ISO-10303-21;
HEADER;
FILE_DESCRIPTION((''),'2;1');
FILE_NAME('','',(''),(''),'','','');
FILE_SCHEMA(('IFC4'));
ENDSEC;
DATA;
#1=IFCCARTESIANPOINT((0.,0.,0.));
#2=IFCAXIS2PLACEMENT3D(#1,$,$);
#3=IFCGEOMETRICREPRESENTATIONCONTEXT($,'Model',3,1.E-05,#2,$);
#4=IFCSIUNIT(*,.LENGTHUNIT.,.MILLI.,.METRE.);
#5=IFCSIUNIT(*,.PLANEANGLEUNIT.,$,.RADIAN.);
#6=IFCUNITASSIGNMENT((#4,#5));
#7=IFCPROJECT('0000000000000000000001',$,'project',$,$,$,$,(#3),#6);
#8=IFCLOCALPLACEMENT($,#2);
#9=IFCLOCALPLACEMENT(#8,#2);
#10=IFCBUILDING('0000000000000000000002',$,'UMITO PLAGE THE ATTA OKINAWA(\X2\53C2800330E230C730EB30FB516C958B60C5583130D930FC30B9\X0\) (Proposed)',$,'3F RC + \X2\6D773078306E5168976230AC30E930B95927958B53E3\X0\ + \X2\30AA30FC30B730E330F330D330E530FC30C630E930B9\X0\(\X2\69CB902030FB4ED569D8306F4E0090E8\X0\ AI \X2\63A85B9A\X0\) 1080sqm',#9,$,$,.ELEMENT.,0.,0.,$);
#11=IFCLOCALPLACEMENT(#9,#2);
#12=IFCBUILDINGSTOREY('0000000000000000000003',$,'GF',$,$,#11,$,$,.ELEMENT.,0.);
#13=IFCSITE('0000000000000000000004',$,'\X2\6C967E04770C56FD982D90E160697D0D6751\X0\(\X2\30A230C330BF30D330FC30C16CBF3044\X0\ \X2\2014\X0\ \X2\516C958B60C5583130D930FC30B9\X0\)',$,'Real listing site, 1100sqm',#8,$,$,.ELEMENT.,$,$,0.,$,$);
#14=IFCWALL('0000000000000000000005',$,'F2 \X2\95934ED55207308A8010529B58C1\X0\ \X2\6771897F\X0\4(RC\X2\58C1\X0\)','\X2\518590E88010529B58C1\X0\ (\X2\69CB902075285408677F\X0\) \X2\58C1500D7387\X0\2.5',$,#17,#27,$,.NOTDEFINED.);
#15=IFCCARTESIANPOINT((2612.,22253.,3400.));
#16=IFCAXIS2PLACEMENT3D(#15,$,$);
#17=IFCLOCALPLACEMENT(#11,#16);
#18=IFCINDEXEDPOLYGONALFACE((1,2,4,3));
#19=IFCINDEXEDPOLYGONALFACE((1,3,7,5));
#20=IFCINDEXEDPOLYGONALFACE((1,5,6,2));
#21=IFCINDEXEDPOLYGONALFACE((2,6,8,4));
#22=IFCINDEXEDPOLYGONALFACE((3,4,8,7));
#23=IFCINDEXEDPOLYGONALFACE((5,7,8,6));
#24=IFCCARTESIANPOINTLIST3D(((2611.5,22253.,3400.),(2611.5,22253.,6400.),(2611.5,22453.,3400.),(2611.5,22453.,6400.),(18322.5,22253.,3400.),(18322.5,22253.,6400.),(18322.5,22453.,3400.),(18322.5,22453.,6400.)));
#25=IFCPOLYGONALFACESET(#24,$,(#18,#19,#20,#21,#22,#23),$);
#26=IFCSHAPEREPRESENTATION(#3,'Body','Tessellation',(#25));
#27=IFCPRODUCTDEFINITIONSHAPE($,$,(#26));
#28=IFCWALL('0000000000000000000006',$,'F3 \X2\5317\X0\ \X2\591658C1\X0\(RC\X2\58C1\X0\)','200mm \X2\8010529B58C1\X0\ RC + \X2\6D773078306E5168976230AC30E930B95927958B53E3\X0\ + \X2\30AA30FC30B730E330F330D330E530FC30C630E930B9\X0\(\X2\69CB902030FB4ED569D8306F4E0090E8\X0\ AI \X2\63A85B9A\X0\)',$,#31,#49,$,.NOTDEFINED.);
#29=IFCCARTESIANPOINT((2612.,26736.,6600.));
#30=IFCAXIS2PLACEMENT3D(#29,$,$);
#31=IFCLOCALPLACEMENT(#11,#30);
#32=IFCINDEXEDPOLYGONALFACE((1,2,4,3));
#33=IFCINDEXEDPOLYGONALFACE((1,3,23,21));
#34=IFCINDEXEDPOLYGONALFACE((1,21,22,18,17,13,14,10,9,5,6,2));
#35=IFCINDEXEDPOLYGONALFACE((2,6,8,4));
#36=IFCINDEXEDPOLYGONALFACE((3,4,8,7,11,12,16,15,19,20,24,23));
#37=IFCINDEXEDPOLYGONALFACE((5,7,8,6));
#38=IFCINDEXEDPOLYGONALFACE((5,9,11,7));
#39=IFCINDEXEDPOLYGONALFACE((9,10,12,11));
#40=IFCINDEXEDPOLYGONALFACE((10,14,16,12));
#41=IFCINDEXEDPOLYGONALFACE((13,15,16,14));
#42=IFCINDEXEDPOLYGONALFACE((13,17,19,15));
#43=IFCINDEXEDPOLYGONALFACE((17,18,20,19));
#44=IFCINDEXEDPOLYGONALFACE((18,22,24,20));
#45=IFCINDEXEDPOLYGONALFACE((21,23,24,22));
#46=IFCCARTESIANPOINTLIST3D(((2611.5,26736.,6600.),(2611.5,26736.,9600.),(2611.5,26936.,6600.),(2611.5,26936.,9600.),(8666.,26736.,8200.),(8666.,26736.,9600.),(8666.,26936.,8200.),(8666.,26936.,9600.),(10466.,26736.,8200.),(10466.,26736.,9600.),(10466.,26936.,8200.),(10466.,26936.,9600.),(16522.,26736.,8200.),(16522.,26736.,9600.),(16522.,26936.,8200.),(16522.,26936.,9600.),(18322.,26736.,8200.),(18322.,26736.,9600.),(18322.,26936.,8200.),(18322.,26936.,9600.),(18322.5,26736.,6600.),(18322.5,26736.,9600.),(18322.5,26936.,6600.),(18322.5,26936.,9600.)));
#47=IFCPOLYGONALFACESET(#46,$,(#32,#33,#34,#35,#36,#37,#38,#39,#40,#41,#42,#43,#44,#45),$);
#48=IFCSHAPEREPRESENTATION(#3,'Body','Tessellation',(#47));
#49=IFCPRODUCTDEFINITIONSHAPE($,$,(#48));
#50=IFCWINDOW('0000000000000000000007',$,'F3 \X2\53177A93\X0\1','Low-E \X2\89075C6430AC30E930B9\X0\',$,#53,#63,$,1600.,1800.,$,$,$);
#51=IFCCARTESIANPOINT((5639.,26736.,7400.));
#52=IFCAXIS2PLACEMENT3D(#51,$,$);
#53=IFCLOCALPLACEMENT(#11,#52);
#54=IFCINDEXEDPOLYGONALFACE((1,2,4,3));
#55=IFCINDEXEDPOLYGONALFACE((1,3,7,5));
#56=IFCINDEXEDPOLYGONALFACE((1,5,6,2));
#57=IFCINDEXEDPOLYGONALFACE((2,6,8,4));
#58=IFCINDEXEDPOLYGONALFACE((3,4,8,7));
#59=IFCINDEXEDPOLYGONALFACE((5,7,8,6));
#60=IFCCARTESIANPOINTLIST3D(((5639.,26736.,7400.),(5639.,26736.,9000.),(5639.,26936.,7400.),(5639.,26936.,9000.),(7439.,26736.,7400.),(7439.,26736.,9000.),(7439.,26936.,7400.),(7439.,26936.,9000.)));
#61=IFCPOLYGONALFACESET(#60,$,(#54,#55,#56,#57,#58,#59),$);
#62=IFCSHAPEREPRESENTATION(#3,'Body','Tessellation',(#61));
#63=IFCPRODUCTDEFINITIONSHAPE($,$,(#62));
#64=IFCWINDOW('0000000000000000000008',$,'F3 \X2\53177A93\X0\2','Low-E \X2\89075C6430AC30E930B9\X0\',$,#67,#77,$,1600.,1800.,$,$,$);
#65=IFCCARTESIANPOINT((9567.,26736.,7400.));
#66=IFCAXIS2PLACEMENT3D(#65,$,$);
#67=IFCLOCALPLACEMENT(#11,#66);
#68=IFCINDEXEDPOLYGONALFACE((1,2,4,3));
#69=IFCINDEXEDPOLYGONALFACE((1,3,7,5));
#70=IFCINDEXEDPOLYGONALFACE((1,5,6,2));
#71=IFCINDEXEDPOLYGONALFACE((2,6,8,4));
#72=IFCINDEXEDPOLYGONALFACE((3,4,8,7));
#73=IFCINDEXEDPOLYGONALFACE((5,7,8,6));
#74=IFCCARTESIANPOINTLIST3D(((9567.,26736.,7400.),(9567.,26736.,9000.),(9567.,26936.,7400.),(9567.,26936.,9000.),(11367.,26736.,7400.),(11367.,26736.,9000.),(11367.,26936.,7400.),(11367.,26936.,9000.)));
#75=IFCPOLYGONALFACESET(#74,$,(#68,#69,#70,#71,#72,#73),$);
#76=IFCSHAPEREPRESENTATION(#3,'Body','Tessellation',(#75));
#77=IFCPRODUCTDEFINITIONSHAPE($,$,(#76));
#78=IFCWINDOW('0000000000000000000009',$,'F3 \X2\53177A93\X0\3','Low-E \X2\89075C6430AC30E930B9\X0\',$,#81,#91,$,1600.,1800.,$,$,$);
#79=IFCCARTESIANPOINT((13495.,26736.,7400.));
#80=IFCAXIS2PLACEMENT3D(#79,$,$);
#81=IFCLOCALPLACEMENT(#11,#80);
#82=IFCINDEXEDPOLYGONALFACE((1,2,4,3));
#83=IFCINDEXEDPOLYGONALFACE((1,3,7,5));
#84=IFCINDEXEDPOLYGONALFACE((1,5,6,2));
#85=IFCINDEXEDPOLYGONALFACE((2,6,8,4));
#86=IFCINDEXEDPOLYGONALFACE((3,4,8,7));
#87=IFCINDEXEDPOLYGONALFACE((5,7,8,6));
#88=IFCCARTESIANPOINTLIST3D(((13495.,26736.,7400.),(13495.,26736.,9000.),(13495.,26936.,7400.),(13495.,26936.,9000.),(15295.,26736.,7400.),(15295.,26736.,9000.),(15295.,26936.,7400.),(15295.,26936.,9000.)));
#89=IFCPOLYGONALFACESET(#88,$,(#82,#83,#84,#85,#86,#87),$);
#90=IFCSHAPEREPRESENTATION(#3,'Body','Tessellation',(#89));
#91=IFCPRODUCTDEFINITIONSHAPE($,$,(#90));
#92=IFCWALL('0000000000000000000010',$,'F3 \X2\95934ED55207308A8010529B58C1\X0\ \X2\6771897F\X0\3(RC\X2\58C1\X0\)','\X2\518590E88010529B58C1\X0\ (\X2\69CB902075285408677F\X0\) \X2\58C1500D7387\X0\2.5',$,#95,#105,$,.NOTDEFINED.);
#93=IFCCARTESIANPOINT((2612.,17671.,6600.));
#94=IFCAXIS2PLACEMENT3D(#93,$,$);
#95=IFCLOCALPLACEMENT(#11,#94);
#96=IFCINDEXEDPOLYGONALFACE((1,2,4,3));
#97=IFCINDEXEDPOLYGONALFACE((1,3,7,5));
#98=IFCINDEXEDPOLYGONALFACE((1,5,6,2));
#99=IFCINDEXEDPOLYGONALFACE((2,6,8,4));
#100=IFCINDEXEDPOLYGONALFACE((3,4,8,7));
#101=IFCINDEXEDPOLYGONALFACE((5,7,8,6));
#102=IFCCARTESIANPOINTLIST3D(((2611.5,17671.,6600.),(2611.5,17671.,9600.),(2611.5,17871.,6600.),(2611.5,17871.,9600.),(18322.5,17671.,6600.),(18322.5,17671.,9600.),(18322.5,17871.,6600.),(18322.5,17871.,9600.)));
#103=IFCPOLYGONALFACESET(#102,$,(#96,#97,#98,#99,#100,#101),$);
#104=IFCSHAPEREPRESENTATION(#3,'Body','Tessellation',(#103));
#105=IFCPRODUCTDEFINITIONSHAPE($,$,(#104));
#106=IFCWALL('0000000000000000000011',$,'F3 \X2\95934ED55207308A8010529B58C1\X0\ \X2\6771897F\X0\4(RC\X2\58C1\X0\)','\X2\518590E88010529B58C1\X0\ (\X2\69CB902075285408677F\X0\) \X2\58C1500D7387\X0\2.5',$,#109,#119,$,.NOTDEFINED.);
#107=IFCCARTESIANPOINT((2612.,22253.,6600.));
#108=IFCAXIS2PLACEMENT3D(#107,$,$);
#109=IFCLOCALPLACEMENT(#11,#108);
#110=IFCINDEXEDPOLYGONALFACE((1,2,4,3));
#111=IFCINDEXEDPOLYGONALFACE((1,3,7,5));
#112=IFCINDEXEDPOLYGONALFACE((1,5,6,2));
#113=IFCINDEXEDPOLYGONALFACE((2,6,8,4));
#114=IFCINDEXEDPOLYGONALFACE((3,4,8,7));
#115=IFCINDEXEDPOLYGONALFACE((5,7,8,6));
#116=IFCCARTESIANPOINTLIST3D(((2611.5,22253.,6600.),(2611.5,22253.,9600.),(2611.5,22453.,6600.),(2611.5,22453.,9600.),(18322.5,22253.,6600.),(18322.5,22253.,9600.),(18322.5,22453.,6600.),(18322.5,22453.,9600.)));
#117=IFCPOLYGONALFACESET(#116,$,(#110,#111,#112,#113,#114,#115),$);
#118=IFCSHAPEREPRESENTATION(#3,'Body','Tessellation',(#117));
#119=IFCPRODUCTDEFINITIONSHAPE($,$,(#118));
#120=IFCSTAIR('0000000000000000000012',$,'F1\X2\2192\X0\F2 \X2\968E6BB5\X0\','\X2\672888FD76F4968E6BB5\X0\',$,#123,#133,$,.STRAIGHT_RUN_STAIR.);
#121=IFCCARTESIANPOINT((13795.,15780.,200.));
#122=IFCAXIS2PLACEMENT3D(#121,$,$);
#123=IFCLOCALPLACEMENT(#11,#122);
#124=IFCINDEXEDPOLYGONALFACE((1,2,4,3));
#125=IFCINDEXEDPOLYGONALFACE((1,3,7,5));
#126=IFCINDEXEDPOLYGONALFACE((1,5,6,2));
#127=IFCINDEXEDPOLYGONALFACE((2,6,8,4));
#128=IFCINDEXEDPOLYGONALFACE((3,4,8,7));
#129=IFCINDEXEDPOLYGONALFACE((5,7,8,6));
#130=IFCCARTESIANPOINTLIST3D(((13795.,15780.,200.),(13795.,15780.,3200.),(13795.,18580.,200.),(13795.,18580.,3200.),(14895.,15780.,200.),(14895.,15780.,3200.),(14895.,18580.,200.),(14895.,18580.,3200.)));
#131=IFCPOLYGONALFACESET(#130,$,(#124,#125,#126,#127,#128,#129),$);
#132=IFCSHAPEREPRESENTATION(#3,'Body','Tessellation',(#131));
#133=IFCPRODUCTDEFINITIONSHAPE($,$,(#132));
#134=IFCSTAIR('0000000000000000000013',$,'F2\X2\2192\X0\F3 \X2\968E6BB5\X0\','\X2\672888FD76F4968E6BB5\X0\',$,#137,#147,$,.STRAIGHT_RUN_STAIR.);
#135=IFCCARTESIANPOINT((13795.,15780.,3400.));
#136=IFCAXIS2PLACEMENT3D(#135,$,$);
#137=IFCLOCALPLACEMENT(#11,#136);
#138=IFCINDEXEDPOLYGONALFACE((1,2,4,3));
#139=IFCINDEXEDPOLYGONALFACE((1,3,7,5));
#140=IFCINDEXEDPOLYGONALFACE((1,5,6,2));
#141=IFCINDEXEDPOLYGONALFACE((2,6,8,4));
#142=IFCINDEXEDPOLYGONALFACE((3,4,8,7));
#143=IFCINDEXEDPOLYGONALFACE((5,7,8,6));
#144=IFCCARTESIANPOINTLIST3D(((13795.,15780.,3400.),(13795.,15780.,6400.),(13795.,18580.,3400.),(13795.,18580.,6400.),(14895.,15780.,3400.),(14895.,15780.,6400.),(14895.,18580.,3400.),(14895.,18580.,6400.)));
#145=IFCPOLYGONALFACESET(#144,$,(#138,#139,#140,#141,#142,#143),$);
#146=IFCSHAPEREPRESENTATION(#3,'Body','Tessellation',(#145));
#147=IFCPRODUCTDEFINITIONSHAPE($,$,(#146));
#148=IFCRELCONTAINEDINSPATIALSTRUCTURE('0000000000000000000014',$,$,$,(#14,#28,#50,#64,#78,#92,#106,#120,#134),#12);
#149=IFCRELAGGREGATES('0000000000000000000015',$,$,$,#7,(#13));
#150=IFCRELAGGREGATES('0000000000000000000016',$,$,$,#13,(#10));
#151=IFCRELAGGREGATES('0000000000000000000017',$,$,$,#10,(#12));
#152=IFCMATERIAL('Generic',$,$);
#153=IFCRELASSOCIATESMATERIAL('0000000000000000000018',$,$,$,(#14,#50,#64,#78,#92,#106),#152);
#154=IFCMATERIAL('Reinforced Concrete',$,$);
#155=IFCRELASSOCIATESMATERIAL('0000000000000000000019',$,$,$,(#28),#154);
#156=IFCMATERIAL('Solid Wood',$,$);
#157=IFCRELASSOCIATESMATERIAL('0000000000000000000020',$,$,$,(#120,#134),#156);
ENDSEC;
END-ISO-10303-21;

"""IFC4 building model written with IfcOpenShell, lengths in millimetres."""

from ifc_helpers import new_model, si_unit, frame, frame_2d, origin, place, context, project, spatial, rectangle, extrude, material, element, fill, save


model = new_model("IFC4")

# Units and contexts
model_context = context("Model", 3, precision=1e-05, world=origin())
ifc_project = project(units=[si_unit("LENGTHUNIT", "METRE", prefix="MILLI"), si_unit("PLANEANGLEUNIT", "RADIAN")], contexts=[model_context])

# Site, building, storey
site_placement = place(None, origin())
site = spatial("IfcSite", under=ifc_project, at=site_placement, Name="沖縄県国頭郡恩納村(アッタビーチ沿い — 公開情報ベース)", ObjectType="Real listing site, 1100sqm", CompositionType="ELEMENT", RefElevation=0.0)
building_placement = place(site_placement, origin())
building = spatial("IfcBuilding", under=site, at=building_placement, Name="UMITO PLAGE THE ATTA OKINAWA(参考モデル・公開情報ベース) (Proposed)", ObjectType="3F RC + 海への全面ガラス大開口 + オーシャンビューテラス(構造・仕様は一部 AI 推定) 1080sqm", CompositionType="ELEMENT", ElevationOfRefHeight=0.0, ElevationOfTerrain=0.0)
storey_placement = place(building_placement, origin())
storey = spatial("IfcBuildingStorey", under=building, at=storey_placement, Name="GF", CompositionType="ELEMENT", Elevation=0.0)

# Shared definitions
ifc_material_1 = material(Name="Reinforced Concrete")
ifc_material_2 = material(Name="Generic")

# Wall
wall_1_placement = place(storey_placement, frame((2612.0, 22253.0, 3400.0)))
element("IfcWall", 1, at=wall_1_placement, inside=storey, material=ifc_material_2, Name="F2 間仕切り耐力壁 東西4(RC壁)", Description="内部耐力壁 (構造用合板) 壁倍率2.5", PredefinedType="NOTDEFINED", context=model_context, shape_type="SweptSolid", body=[
    extrude(rectangle(XDim=15711.0, YDim=200.0, at=frame_2d((7855.0, 100.0))), frame((2612.0, 22253.0, 3400.0)), (0.0, 0.0, 1.0), 3000.0),
])

# Wall, openings, windows
wall_2_placement = place(storey_placement, frame((2612.0, 26736.0, 6600.0)))
wall_2 = element("IfcWall", 2, at=wall_2_placement, inside=storey, material=ifc_material_1, Name="F3 北 外壁(RC壁)", Description="200mm 耐力壁 RC + 海への全面ガラス大開口 + オーシャンビューテラス(構造・仕様は一部 AI 推定)", PredefinedType="NOTDEFINED", context=model_context, shape_type="SweptSolid", body=[
    extrude(rectangle(XDim=15711.0, YDim=200.0, at=frame_2d((7855.0, 100.0))), frame((2612.0, 26736.0, 6600.0)), (0.0, 0.0, 1.0), 3000.0),
])
opening_1_placement = place(storey_placement, frame((5639.0, 26736.0, 7400.0)))
opening_1 = element("IfcOpeningElement", 3, at=opening_1_placement, cuts=wall_2, PredefinedType="NOTDEFINED", context=model_context, shape_type="SweptSolid", body=[
    extrude(rectangle(XDim=1800.0, YDim=200.0, at=frame_2d((900.0, 100.0))), frame((5639.0, 26736.0, 7400.0)), (0.0, 0.0, 1.0), 1600.0),
])
opening_2_placement = place(storey_placement, frame((9567.0, 26736.0, 7400.0)))
opening_2 = element("IfcOpeningElement", 4, at=opening_2_placement, cuts=wall_2, PredefinedType="NOTDEFINED", context=model_context, shape_type="SweptSolid", body=[
    extrude(rectangle(XDim=1800.0, YDim=200.0, at=frame_2d((900.0, 100.0))), frame((9567.0, 26736.0, 7400.0)), (0.0, 0.0, 1.0), 1600.0),
])
opening_3_placement = place(storey_placement, frame((13495.0, 26736.0, 7400.0)))
opening_3 = element("IfcOpeningElement", 5, at=opening_3_placement, cuts=wall_2, PredefinedType="NOTDEFINED", context=model_context, shape_type="SweptSolid", body=[
    extrude(rectangle(XDim=1800.0, YDim=200.0, at=frame_2d((900.0, 100.0))), frame((13495.0, 26736.0, 7400.0)), (0.0, 0.0, 1.0), 1600.0),
])
window_1_placement = place(storey_placement, frame((5639.0, 26736.0, 7400.0)))
window_1 = element("IfcWindow", 6, at=window_1_placement, inside=storey, material=ifc_material_2, Name="F3 北窓1", Description="Low-E 複層ガラス", OverallHeight=1600.0, OverallWidth=1800.0, context=model_context, shape_type="SweptSolid", body=[
    extrude(rectangle(XDim=1800.0, YDim=200.0, at=frame_2d((900.0, 100.0))), frame((5639.0, 26736.0, 7400.0)), (0.0, 0.0, 1.0), 1600.0),
])
fill(opening_1, window_1)
window_2_placement = place(storey_placement, frame((9567.0, 26736.0, 7400.0)))
window_2 = element("IfcWindow", 7, at=window_2_placement, inside=storey, material=ifc_material_2, Name="F3 北窓2", Description="Low-E 複層ガラス", OverallHeight=1600.0, OverallWidth=1800.0, context=model_context, shape_type="SweptSolid", body=[
    extrude(rectangle(XDim=1800.0, YDim=200.0, at=frame_2d((900.0, 100.0))), frame((9567.0, 26736.0, 7400.0)), (0.0, 0.0, 1.0), 1600.0),
])
fill(opening_2, window_2)
window_3_placement = place(storey_placement, frame((13495.0, 26736.0, 7400.0)))
window_3 = element("IfcWindow", 8, at=window_3_placement, inside=storey, material=ifc_material_2, Name="F3 北窓3", Description="Low-E 複層ガラス", OverallHeight=1600.0, OverallWidth=1800.0, context=model_context, shape_type="SweptSolid", body=[
    extrude(rectangle(XDim=1800.0, YDim=200.0, at=frame_2d((900.0, 100.0))), frame((13495.0, 26736.0, 7400.0)), (0.0, 0.0, 1.0), 1600.0),
])
fill(opening_3, window_3)

# Walls
wall_3_placement = place(storey_placement, frame((2612.0, 17671.0, 6600.0)))
element("IfcWall", 9, at=wall_3_placement, inside=storey, material=ifc_material_2, Name="F3 間仕切り耐力壁 東西3(RC壁)", Description="内部耐力壁 (構造用合板) 壁倍率2.5", PredefinedType="NOTDEFINED", context=model_context, shape_type="SweptSolid", body=[
    extrude(rectangle(XDim=15711.0, YDim=200.0, at=frame_2d((7855.0, 100.0))), frame((2612.0, 17671.0, 6600.0)), (0.0, 0.0, 1.0), 3000.0),
])
wall_4_placement = place(storey_placement, frame((2612.0, 22253.0, 6600.0)))
element("IfcWall", 10, at=wall_4_placement, inside=storey, material=ifc_material_2, Name="F3 間仕切り耐力壁 東西4(RC壁)", Description="内部耐力壁 (構造用合板) 壁倍率2.5", PredefinedType="NOTDEFINED", context=model_context, shape_type="SweptSolid", body=[
    extrude(rectangle(XDim=15711.0, YDim=200.0, at=frame_2d((7855.0, 100.0))), frame((2612.0, 22253.0, 6600.0)), (0.0, 0.0, 1.0), 3000.0),
])

# Stairs
ifc_material_3 = material(Name="Solid Wood")
stair_1_placement = place(storey_placement, frame((13795.0, 15780.0, 200.0)))
element("IfcStair", 11, at=stair_1_placement, inside=storey, material=ifc_material_3, Name="F1→F2 階段", Description="木製直階段", PredefinedType="STRAIGHT_RUN_STAIR", context=model_context, shape_type="SweptSolid", body=[
    extrude(rectangle(XDim=1100.0, YDim=2800.0, at=frame_2d((550.0, 1400.0))), frame((13795.0, 15780.0, 200.0)), (0.0, 0.0, 1.0), 3000.0),
])
stair_2_placement = place(storey_placement, frame((13795.0, 15780.0, 3400.0)))
element("IfcStair", 12, at=stair_2_placement, inside=storey, material=ifc_material_3, Name="F2→F3 階段", Description="木製直階段", PredefinedType="STRAIGHT_RUN_STAIR", context=model_context, shape_type="SweptSolid", body=[
    extrude(rectangle(XDim=1100.0, YDim=2800.0, at=frame_2d((550.0, 1400.0))), frame((13795.0, 15780.0, 3400.0)), (0.0, 0.0, 1.0), 3000.0),
])

save(model, "model.ifc")
